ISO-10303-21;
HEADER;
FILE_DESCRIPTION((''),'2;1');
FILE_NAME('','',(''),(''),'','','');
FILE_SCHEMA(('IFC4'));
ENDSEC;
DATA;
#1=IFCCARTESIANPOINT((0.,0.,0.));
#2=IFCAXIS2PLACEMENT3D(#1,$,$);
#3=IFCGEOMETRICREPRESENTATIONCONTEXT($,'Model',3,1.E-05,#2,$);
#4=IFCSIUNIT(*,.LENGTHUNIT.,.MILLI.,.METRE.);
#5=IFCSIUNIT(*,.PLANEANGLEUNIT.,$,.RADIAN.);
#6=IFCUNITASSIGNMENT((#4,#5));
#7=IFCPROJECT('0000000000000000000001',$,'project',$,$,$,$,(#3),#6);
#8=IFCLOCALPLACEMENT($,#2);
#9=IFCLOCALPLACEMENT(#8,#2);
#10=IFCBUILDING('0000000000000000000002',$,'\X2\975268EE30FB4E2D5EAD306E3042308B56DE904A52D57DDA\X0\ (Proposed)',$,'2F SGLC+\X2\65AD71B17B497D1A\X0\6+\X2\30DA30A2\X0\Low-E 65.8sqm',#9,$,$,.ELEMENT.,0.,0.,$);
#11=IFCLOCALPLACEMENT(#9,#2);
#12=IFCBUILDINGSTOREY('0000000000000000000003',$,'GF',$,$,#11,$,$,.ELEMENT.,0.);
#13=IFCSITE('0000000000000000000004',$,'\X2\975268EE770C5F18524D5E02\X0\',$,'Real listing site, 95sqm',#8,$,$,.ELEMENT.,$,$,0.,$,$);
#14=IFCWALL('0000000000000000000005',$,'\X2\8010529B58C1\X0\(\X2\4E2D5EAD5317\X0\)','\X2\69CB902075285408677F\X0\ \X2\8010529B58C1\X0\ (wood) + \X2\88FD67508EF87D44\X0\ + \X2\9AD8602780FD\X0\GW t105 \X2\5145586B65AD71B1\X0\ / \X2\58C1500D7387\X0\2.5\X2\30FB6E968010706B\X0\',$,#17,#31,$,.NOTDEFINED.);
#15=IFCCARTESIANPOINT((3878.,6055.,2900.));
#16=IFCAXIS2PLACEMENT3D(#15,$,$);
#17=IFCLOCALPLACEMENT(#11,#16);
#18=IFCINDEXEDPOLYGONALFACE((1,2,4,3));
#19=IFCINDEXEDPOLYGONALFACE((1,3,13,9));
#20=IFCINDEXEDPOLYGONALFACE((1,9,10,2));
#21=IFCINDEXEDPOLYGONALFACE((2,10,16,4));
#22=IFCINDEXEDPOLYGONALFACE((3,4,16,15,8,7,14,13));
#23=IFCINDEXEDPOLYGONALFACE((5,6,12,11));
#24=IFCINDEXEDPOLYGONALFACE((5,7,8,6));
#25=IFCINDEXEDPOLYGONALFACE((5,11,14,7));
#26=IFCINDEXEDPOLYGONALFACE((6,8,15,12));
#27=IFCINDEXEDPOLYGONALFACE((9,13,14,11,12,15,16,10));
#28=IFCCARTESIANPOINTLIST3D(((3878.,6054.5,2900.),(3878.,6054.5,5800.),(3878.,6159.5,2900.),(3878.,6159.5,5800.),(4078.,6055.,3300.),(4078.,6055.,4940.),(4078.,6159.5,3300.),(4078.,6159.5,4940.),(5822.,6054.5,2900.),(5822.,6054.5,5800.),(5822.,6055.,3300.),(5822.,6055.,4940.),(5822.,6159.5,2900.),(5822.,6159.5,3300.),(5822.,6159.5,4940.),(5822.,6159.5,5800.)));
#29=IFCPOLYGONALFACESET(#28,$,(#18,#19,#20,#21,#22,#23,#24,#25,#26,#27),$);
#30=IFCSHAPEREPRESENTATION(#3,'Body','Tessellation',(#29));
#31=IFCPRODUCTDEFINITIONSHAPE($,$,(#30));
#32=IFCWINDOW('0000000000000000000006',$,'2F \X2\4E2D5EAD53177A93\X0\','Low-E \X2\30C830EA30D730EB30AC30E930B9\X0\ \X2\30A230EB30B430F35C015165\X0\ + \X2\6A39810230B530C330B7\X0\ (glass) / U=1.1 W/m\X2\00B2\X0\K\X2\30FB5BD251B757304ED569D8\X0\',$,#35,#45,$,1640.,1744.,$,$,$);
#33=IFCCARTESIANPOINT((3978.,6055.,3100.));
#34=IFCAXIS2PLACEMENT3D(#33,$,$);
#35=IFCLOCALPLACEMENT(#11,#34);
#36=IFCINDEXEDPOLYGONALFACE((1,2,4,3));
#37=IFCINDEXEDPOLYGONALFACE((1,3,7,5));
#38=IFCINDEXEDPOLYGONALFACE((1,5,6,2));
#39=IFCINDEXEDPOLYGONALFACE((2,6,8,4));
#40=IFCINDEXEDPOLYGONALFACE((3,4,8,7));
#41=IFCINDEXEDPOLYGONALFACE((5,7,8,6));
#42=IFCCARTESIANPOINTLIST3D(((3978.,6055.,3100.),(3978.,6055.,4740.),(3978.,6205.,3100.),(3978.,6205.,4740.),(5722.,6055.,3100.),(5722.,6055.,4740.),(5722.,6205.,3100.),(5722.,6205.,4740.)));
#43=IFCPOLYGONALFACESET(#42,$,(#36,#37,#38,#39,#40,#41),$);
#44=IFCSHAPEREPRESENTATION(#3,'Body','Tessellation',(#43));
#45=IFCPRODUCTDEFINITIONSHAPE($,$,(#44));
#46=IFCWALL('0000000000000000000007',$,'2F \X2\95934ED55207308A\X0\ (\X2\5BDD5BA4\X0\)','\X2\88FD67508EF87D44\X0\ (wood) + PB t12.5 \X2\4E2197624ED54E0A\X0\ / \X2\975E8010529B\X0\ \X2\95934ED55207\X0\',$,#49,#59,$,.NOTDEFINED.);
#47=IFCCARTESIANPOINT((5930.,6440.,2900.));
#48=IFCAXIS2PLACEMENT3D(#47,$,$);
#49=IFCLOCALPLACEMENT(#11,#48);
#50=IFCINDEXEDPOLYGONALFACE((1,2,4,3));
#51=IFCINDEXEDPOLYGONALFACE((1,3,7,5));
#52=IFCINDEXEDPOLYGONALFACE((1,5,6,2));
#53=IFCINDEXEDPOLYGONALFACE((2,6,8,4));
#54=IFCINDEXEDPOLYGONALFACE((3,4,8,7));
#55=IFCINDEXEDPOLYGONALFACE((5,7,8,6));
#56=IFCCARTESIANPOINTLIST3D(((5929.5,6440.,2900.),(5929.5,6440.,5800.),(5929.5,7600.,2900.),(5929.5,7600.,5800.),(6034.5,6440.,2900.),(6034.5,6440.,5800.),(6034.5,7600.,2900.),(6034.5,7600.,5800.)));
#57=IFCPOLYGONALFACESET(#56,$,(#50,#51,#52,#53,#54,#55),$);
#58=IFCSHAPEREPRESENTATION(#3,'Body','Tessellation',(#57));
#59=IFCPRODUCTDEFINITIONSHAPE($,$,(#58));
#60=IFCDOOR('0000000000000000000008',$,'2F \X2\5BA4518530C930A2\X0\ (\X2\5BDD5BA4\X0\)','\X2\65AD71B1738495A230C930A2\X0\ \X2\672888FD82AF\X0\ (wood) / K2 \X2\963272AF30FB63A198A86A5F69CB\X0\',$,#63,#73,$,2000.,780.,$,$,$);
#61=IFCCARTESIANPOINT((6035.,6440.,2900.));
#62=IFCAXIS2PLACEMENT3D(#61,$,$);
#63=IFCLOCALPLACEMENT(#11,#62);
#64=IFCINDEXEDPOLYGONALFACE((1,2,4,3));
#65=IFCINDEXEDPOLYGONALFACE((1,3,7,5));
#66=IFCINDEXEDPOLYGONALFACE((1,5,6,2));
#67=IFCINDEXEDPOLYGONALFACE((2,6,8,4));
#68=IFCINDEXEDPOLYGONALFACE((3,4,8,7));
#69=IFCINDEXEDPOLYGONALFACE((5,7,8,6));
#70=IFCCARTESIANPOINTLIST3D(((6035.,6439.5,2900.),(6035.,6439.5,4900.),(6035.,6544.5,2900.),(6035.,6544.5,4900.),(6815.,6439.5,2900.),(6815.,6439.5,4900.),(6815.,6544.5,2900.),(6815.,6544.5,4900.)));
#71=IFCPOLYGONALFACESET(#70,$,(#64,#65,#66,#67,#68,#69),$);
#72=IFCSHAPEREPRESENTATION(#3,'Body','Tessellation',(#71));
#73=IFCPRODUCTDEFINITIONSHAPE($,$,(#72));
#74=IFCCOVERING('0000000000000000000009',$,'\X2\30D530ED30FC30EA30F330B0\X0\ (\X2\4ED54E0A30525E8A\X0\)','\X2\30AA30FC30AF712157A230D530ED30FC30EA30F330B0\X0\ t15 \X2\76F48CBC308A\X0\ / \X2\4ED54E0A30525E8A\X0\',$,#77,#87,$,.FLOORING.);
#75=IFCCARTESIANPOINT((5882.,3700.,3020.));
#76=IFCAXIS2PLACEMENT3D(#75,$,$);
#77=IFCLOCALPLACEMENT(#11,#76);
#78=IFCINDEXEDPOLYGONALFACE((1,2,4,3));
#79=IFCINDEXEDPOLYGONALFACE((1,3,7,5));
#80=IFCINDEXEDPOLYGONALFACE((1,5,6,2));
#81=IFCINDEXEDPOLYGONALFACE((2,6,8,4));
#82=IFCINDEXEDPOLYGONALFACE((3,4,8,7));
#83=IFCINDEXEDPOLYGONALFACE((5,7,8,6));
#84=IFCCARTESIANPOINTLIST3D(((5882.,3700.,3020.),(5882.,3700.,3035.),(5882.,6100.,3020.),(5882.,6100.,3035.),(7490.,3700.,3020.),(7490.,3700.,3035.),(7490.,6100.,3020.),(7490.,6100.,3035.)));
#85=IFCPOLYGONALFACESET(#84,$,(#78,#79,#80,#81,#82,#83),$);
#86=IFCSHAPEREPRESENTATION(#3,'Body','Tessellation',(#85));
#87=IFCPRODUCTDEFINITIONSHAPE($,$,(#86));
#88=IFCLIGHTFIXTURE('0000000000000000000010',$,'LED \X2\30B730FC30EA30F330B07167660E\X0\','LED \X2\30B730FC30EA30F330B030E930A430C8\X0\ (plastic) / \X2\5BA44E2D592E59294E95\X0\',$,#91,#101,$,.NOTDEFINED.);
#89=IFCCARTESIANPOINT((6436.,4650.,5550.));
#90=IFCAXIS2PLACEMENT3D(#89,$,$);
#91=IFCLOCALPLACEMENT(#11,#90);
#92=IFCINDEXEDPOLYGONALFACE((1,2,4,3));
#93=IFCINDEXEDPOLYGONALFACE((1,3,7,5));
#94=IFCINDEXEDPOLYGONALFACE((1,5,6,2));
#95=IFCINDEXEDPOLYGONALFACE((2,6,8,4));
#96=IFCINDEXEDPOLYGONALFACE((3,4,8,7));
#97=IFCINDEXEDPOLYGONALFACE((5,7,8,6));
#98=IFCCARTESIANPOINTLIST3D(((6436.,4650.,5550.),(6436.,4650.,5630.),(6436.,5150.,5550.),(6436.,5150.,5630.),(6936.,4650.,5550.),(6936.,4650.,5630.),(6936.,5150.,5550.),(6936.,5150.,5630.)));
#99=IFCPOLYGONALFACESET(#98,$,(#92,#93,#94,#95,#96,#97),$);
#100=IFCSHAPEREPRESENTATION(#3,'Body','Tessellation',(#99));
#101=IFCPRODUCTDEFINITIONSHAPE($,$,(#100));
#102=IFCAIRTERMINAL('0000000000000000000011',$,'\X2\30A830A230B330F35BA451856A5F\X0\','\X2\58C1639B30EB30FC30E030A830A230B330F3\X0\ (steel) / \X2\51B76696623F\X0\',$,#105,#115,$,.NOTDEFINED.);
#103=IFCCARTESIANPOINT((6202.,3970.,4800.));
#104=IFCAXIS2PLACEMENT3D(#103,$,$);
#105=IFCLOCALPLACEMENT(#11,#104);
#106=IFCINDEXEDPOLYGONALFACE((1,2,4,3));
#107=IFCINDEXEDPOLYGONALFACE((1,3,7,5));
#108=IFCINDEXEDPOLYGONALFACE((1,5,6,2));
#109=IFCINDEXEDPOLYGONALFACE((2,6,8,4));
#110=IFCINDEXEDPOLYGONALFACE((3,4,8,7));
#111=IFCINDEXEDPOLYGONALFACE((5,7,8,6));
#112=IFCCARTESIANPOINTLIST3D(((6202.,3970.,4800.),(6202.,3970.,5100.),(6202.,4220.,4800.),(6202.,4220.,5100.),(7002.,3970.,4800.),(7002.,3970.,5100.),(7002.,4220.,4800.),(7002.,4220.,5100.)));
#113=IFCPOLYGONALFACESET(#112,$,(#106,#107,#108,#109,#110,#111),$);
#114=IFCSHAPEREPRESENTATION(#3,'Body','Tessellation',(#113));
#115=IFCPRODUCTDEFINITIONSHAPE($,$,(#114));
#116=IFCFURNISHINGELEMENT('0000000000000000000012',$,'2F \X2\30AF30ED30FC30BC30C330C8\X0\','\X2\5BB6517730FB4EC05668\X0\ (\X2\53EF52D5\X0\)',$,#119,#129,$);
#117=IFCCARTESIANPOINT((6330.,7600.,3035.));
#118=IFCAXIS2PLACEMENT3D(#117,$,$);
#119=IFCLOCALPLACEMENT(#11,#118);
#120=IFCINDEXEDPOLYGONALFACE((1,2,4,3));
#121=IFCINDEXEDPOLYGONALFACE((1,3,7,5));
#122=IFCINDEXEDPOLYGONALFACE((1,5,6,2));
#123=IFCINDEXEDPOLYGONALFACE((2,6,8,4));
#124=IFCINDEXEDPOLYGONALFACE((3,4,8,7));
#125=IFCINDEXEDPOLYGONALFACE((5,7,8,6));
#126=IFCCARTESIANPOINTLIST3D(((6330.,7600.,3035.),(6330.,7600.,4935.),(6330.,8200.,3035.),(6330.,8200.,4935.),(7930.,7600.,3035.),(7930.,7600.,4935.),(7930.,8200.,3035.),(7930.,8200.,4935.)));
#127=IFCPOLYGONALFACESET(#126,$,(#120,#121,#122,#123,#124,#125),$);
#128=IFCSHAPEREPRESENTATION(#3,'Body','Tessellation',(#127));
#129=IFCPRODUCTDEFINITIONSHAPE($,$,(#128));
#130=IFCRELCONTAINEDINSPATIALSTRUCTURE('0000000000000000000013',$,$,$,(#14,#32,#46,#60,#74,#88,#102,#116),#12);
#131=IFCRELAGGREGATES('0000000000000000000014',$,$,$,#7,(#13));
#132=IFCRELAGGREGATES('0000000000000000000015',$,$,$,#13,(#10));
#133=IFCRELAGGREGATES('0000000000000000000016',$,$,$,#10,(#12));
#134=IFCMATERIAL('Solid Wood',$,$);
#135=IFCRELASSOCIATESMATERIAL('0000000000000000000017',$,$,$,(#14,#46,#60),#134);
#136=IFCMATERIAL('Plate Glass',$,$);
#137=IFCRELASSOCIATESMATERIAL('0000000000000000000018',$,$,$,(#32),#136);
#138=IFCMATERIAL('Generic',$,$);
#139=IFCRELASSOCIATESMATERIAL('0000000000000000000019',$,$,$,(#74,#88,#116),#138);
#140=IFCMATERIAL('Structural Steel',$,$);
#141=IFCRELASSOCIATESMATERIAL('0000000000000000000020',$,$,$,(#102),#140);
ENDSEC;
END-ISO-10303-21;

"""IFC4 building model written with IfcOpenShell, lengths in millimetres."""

from ifc_helpers import new_model, si_unit, frame, frame_2d, origin, place, context, project, spatial, rectangle, extrude, material, element, fill, save


model = new_model("IFC4")

# Units and contexts
model_context = context("Model", 3, precision=1e-05, world=origin())
ifc_project = project(units=[si_unit("LENGTHUNIT", "METRE", prefix="MILLI"), si_unit("PLANEANGLEUNIT", "RADIAN")], contexts=[model_context])

# Site, building, storey
site_placement = place(None, origin())
site = spatial("IfcSite", under=ifc_project, at=site_placement, Name="青森県弘前市", ObjectType="Real listing site, 95sqm", CompositionType="ELEMENT", RefElevation=0.0)
building_placement = place(site_placement, origin())
building = spatial("IfcBuilding", under=site, at=building_placement, Name="青森・中庭のある回遊動線 (Proposed)", ObjectType="2F SGLC+断熱等級6+ペアLow-E 65.8sqm", CompositionType="ELEMENT", ElevationOfRefHeight=0.0, ElevationOfTerrain=0.0)
storey_placement = place(building_placement, origin())
storey = spatial("IfcBuildingStorey", under=building, at=storey_placement, Name="GF", CompositionType="ELEMENT", Elevation=0.0)

# Shared definitions
ifc_material_1 = material(Name="Solid Wood")

# Wall, opening, window
wall_1_placement = place(storey_placement, frame((3878.0, 6055.0, 2900.0)))
wall_1 = element("IfcWall", 1, at=wall_1_placement, inside=storey, material=ifc_material_1, Name="耐力壁(中庭北)", Description="構造用合板 耐力壁 (wood) + 製材軸組 + 高性能GW t105 充填断熱 / 壁倍率2.5・準耐火", PredefinedType="NOTDEFINED", context=model_context, shape_type="SweptSolid", body=[
    extrude(rectangle(XDim=1944.0, YDim=105.0, at=frame_2d((972.0, 52.0))), frame((3878.0, 6055.0, 2900.0)), (0.0, 0.0, 1.0), 2900.0),
])
opening_placement = place(storey_placement, frame((3978.0, 6055.0, 3100.0)))
opening = element("IfcOpeningElement", 2, at=opening_placement, cuts=wall_1, PredefinedType="NOTDEFINED", context=model_context, shape_type="SweptSolid", body=[
    extrude(rectangle(XDim=1744.0, YDim=150.0, at=frame_2d((872.0, 75.0))), frame((3978.0, 6055.0, 3100.0)), (0.0, 0.0, 1.0), 1640.0),
])
ifc_material_2 = material(Name="Plate Glass")
window_placement = place(storey_placement, frame((3978.0, 6055.0, 3100.0)))
window = element("IfcWindow", 3, at=window_placement, inside=storey, material=ifc_material_2, Name="2F 中庭北窓", Description="Low-E トリプルガラス アルゴン封入 + 樹脂サッシ (glass) / U=1.1 W/m²K・寒冷地仕様", OverallHeight=1640.0, OverallWidth=1744.0, context=model_context, shape_type="SweptSolid", body=[
    extrude(rectangle(XDim=1744.0, YDim=150.0, at=frame_2d((872.0, 75.0))), frame((3978.0, 6055.0, 3100.0)), (0.0, 0.0, 1.0), 1640.0),
])
fill(opening, window)

# Wall
wall_2_placement = place(storey_placement, frame((5930.0, 6440.0, 2900.0)))
element("IfcWall", 4, at=wall_2_placement, inside=storey, material=ifc_material_1, Name="2F 間仕切り (寝室)", Description="製材軸組 (wood) + PB t12.5 両面仕上 / 非耐力 間仕切", PredefinedType="NOTDEFINED", context=model_context, shape_type="SweptSolid", body=[
    extrude(rectangle(XDim=105.0, YDim=1160.0, at=frame_2d((52.0, 580.0))), frame((5930.0, 6440.0, 2900.0)), (0.0, 0.0, 1.0), 2900.0),
])

# Door
door_placement = place(storey_placement, frame((6035.0, 6440.0, 2900.0)))
element("IfcDoor", 5, at=door_placement, inside=storey, material=ifc_material_1, Name="2F 室内ドア (寝室)", Description="断熱玄関ドア 木製芯 (wood) / K2 防犯・採風機構", OverallHeight=2000.0, OverallWidth=780.0, context=model_context, shape_type="SweptSolid", body=[
    extrude(rectangle(XDim=780.0, YDim=105.0, at=frame_2d((390.0, 52.0))), frame((6035.0, 6440.0, 2900.0)), (0.0, 0.0, 1.0), 2000.0),
])

# Covering
ifc_material_3 = material(Name="Generic")
covering_placement = place(storey_placement, frame((5882.0, 3700.0, 3020.0)))
element("IfcCovering", 6, at=covering_placement, inside=storey, material=ifc_material_3, Name="フローリング (仕上げ床)", Description="オーク無垢フローリング t15 直貼り / 仕上げ床", PredefinedType="FLOORING", context=model_context, shape_type="SweptSolid", body=[
    extrude(rectangle(XDim=1608.0, YDim=2400.0, at=frame_2d((804.0, 1200.0))), frame((5882.0, 3700.0, 3020.0)), (0.0, 0.0, 1.0), 15.0),
])

# Light fixture
light_fixture_placement = place(storey_placement, frame((6436.0, 4650.0, 5550.0)))
element("IfcLightFixture", 7, at=light_fixture_placement, inside=storey, material=ifc_material_3, Name="LED シーリング照明", Description="LED シーリングライト (plastic) / 室中央天井", PredefinedType="NOTDEFINED", context=model_context, shape_type="SweptSolid", body=[
    extrude(rectangle(XDim=500.0, YDim=500.0, at=frame_2d((250.0, 250.0))), frame((6436.0, 4650.0, 5550.0)), (0.0, 0.0, 1.0), 80.0),
])

# Air terminal
ifc_material_4 = material(Name="Structural Steel")
air_terminal_placement = place(storey_placement, frame((6202.0, 3970.0, 4800.0)))
element("IfcAirTerminal", 8, at=air_terminal_placement, inside=storey, material=ifc_material_4, Name="エアコン室内機", Description="壁掛ルームエアコン (steel) / 冷暖房", PredefinedType="NOTDEFINED", context=model_context, shape_type="SweptSolid", body=[
    extrude(rectangle(XDim=800.0, YDim=250.0, at=frame_2d((400.0, 125.0))), frame((6202.0, 3970.0, 4800.0)), (0.0, 0.0, 1.0), 300.0),
])

# Furnishing element
furnishing_placement = place(storey_placement, frame((6330.0, 7600.0, 3035.0)))
element("IfcFurnishingElement", 9, at=furnishing_placement, inside=storey, material=ifc_material_3, Name="2F クローゼット", Description="家具・什器 (可動)", context=model_context, shape_type="SweptSolid", body=[
    extrude(rectangle(XDim=1600.0, YDim=600.0, at=frame_2d((800.0, 300.0))), frame((6330.0, 7600.0, 3035.0)), (0.0, 0.0, 1.0), 1900.0),
])

save(model, "model.ifc")
